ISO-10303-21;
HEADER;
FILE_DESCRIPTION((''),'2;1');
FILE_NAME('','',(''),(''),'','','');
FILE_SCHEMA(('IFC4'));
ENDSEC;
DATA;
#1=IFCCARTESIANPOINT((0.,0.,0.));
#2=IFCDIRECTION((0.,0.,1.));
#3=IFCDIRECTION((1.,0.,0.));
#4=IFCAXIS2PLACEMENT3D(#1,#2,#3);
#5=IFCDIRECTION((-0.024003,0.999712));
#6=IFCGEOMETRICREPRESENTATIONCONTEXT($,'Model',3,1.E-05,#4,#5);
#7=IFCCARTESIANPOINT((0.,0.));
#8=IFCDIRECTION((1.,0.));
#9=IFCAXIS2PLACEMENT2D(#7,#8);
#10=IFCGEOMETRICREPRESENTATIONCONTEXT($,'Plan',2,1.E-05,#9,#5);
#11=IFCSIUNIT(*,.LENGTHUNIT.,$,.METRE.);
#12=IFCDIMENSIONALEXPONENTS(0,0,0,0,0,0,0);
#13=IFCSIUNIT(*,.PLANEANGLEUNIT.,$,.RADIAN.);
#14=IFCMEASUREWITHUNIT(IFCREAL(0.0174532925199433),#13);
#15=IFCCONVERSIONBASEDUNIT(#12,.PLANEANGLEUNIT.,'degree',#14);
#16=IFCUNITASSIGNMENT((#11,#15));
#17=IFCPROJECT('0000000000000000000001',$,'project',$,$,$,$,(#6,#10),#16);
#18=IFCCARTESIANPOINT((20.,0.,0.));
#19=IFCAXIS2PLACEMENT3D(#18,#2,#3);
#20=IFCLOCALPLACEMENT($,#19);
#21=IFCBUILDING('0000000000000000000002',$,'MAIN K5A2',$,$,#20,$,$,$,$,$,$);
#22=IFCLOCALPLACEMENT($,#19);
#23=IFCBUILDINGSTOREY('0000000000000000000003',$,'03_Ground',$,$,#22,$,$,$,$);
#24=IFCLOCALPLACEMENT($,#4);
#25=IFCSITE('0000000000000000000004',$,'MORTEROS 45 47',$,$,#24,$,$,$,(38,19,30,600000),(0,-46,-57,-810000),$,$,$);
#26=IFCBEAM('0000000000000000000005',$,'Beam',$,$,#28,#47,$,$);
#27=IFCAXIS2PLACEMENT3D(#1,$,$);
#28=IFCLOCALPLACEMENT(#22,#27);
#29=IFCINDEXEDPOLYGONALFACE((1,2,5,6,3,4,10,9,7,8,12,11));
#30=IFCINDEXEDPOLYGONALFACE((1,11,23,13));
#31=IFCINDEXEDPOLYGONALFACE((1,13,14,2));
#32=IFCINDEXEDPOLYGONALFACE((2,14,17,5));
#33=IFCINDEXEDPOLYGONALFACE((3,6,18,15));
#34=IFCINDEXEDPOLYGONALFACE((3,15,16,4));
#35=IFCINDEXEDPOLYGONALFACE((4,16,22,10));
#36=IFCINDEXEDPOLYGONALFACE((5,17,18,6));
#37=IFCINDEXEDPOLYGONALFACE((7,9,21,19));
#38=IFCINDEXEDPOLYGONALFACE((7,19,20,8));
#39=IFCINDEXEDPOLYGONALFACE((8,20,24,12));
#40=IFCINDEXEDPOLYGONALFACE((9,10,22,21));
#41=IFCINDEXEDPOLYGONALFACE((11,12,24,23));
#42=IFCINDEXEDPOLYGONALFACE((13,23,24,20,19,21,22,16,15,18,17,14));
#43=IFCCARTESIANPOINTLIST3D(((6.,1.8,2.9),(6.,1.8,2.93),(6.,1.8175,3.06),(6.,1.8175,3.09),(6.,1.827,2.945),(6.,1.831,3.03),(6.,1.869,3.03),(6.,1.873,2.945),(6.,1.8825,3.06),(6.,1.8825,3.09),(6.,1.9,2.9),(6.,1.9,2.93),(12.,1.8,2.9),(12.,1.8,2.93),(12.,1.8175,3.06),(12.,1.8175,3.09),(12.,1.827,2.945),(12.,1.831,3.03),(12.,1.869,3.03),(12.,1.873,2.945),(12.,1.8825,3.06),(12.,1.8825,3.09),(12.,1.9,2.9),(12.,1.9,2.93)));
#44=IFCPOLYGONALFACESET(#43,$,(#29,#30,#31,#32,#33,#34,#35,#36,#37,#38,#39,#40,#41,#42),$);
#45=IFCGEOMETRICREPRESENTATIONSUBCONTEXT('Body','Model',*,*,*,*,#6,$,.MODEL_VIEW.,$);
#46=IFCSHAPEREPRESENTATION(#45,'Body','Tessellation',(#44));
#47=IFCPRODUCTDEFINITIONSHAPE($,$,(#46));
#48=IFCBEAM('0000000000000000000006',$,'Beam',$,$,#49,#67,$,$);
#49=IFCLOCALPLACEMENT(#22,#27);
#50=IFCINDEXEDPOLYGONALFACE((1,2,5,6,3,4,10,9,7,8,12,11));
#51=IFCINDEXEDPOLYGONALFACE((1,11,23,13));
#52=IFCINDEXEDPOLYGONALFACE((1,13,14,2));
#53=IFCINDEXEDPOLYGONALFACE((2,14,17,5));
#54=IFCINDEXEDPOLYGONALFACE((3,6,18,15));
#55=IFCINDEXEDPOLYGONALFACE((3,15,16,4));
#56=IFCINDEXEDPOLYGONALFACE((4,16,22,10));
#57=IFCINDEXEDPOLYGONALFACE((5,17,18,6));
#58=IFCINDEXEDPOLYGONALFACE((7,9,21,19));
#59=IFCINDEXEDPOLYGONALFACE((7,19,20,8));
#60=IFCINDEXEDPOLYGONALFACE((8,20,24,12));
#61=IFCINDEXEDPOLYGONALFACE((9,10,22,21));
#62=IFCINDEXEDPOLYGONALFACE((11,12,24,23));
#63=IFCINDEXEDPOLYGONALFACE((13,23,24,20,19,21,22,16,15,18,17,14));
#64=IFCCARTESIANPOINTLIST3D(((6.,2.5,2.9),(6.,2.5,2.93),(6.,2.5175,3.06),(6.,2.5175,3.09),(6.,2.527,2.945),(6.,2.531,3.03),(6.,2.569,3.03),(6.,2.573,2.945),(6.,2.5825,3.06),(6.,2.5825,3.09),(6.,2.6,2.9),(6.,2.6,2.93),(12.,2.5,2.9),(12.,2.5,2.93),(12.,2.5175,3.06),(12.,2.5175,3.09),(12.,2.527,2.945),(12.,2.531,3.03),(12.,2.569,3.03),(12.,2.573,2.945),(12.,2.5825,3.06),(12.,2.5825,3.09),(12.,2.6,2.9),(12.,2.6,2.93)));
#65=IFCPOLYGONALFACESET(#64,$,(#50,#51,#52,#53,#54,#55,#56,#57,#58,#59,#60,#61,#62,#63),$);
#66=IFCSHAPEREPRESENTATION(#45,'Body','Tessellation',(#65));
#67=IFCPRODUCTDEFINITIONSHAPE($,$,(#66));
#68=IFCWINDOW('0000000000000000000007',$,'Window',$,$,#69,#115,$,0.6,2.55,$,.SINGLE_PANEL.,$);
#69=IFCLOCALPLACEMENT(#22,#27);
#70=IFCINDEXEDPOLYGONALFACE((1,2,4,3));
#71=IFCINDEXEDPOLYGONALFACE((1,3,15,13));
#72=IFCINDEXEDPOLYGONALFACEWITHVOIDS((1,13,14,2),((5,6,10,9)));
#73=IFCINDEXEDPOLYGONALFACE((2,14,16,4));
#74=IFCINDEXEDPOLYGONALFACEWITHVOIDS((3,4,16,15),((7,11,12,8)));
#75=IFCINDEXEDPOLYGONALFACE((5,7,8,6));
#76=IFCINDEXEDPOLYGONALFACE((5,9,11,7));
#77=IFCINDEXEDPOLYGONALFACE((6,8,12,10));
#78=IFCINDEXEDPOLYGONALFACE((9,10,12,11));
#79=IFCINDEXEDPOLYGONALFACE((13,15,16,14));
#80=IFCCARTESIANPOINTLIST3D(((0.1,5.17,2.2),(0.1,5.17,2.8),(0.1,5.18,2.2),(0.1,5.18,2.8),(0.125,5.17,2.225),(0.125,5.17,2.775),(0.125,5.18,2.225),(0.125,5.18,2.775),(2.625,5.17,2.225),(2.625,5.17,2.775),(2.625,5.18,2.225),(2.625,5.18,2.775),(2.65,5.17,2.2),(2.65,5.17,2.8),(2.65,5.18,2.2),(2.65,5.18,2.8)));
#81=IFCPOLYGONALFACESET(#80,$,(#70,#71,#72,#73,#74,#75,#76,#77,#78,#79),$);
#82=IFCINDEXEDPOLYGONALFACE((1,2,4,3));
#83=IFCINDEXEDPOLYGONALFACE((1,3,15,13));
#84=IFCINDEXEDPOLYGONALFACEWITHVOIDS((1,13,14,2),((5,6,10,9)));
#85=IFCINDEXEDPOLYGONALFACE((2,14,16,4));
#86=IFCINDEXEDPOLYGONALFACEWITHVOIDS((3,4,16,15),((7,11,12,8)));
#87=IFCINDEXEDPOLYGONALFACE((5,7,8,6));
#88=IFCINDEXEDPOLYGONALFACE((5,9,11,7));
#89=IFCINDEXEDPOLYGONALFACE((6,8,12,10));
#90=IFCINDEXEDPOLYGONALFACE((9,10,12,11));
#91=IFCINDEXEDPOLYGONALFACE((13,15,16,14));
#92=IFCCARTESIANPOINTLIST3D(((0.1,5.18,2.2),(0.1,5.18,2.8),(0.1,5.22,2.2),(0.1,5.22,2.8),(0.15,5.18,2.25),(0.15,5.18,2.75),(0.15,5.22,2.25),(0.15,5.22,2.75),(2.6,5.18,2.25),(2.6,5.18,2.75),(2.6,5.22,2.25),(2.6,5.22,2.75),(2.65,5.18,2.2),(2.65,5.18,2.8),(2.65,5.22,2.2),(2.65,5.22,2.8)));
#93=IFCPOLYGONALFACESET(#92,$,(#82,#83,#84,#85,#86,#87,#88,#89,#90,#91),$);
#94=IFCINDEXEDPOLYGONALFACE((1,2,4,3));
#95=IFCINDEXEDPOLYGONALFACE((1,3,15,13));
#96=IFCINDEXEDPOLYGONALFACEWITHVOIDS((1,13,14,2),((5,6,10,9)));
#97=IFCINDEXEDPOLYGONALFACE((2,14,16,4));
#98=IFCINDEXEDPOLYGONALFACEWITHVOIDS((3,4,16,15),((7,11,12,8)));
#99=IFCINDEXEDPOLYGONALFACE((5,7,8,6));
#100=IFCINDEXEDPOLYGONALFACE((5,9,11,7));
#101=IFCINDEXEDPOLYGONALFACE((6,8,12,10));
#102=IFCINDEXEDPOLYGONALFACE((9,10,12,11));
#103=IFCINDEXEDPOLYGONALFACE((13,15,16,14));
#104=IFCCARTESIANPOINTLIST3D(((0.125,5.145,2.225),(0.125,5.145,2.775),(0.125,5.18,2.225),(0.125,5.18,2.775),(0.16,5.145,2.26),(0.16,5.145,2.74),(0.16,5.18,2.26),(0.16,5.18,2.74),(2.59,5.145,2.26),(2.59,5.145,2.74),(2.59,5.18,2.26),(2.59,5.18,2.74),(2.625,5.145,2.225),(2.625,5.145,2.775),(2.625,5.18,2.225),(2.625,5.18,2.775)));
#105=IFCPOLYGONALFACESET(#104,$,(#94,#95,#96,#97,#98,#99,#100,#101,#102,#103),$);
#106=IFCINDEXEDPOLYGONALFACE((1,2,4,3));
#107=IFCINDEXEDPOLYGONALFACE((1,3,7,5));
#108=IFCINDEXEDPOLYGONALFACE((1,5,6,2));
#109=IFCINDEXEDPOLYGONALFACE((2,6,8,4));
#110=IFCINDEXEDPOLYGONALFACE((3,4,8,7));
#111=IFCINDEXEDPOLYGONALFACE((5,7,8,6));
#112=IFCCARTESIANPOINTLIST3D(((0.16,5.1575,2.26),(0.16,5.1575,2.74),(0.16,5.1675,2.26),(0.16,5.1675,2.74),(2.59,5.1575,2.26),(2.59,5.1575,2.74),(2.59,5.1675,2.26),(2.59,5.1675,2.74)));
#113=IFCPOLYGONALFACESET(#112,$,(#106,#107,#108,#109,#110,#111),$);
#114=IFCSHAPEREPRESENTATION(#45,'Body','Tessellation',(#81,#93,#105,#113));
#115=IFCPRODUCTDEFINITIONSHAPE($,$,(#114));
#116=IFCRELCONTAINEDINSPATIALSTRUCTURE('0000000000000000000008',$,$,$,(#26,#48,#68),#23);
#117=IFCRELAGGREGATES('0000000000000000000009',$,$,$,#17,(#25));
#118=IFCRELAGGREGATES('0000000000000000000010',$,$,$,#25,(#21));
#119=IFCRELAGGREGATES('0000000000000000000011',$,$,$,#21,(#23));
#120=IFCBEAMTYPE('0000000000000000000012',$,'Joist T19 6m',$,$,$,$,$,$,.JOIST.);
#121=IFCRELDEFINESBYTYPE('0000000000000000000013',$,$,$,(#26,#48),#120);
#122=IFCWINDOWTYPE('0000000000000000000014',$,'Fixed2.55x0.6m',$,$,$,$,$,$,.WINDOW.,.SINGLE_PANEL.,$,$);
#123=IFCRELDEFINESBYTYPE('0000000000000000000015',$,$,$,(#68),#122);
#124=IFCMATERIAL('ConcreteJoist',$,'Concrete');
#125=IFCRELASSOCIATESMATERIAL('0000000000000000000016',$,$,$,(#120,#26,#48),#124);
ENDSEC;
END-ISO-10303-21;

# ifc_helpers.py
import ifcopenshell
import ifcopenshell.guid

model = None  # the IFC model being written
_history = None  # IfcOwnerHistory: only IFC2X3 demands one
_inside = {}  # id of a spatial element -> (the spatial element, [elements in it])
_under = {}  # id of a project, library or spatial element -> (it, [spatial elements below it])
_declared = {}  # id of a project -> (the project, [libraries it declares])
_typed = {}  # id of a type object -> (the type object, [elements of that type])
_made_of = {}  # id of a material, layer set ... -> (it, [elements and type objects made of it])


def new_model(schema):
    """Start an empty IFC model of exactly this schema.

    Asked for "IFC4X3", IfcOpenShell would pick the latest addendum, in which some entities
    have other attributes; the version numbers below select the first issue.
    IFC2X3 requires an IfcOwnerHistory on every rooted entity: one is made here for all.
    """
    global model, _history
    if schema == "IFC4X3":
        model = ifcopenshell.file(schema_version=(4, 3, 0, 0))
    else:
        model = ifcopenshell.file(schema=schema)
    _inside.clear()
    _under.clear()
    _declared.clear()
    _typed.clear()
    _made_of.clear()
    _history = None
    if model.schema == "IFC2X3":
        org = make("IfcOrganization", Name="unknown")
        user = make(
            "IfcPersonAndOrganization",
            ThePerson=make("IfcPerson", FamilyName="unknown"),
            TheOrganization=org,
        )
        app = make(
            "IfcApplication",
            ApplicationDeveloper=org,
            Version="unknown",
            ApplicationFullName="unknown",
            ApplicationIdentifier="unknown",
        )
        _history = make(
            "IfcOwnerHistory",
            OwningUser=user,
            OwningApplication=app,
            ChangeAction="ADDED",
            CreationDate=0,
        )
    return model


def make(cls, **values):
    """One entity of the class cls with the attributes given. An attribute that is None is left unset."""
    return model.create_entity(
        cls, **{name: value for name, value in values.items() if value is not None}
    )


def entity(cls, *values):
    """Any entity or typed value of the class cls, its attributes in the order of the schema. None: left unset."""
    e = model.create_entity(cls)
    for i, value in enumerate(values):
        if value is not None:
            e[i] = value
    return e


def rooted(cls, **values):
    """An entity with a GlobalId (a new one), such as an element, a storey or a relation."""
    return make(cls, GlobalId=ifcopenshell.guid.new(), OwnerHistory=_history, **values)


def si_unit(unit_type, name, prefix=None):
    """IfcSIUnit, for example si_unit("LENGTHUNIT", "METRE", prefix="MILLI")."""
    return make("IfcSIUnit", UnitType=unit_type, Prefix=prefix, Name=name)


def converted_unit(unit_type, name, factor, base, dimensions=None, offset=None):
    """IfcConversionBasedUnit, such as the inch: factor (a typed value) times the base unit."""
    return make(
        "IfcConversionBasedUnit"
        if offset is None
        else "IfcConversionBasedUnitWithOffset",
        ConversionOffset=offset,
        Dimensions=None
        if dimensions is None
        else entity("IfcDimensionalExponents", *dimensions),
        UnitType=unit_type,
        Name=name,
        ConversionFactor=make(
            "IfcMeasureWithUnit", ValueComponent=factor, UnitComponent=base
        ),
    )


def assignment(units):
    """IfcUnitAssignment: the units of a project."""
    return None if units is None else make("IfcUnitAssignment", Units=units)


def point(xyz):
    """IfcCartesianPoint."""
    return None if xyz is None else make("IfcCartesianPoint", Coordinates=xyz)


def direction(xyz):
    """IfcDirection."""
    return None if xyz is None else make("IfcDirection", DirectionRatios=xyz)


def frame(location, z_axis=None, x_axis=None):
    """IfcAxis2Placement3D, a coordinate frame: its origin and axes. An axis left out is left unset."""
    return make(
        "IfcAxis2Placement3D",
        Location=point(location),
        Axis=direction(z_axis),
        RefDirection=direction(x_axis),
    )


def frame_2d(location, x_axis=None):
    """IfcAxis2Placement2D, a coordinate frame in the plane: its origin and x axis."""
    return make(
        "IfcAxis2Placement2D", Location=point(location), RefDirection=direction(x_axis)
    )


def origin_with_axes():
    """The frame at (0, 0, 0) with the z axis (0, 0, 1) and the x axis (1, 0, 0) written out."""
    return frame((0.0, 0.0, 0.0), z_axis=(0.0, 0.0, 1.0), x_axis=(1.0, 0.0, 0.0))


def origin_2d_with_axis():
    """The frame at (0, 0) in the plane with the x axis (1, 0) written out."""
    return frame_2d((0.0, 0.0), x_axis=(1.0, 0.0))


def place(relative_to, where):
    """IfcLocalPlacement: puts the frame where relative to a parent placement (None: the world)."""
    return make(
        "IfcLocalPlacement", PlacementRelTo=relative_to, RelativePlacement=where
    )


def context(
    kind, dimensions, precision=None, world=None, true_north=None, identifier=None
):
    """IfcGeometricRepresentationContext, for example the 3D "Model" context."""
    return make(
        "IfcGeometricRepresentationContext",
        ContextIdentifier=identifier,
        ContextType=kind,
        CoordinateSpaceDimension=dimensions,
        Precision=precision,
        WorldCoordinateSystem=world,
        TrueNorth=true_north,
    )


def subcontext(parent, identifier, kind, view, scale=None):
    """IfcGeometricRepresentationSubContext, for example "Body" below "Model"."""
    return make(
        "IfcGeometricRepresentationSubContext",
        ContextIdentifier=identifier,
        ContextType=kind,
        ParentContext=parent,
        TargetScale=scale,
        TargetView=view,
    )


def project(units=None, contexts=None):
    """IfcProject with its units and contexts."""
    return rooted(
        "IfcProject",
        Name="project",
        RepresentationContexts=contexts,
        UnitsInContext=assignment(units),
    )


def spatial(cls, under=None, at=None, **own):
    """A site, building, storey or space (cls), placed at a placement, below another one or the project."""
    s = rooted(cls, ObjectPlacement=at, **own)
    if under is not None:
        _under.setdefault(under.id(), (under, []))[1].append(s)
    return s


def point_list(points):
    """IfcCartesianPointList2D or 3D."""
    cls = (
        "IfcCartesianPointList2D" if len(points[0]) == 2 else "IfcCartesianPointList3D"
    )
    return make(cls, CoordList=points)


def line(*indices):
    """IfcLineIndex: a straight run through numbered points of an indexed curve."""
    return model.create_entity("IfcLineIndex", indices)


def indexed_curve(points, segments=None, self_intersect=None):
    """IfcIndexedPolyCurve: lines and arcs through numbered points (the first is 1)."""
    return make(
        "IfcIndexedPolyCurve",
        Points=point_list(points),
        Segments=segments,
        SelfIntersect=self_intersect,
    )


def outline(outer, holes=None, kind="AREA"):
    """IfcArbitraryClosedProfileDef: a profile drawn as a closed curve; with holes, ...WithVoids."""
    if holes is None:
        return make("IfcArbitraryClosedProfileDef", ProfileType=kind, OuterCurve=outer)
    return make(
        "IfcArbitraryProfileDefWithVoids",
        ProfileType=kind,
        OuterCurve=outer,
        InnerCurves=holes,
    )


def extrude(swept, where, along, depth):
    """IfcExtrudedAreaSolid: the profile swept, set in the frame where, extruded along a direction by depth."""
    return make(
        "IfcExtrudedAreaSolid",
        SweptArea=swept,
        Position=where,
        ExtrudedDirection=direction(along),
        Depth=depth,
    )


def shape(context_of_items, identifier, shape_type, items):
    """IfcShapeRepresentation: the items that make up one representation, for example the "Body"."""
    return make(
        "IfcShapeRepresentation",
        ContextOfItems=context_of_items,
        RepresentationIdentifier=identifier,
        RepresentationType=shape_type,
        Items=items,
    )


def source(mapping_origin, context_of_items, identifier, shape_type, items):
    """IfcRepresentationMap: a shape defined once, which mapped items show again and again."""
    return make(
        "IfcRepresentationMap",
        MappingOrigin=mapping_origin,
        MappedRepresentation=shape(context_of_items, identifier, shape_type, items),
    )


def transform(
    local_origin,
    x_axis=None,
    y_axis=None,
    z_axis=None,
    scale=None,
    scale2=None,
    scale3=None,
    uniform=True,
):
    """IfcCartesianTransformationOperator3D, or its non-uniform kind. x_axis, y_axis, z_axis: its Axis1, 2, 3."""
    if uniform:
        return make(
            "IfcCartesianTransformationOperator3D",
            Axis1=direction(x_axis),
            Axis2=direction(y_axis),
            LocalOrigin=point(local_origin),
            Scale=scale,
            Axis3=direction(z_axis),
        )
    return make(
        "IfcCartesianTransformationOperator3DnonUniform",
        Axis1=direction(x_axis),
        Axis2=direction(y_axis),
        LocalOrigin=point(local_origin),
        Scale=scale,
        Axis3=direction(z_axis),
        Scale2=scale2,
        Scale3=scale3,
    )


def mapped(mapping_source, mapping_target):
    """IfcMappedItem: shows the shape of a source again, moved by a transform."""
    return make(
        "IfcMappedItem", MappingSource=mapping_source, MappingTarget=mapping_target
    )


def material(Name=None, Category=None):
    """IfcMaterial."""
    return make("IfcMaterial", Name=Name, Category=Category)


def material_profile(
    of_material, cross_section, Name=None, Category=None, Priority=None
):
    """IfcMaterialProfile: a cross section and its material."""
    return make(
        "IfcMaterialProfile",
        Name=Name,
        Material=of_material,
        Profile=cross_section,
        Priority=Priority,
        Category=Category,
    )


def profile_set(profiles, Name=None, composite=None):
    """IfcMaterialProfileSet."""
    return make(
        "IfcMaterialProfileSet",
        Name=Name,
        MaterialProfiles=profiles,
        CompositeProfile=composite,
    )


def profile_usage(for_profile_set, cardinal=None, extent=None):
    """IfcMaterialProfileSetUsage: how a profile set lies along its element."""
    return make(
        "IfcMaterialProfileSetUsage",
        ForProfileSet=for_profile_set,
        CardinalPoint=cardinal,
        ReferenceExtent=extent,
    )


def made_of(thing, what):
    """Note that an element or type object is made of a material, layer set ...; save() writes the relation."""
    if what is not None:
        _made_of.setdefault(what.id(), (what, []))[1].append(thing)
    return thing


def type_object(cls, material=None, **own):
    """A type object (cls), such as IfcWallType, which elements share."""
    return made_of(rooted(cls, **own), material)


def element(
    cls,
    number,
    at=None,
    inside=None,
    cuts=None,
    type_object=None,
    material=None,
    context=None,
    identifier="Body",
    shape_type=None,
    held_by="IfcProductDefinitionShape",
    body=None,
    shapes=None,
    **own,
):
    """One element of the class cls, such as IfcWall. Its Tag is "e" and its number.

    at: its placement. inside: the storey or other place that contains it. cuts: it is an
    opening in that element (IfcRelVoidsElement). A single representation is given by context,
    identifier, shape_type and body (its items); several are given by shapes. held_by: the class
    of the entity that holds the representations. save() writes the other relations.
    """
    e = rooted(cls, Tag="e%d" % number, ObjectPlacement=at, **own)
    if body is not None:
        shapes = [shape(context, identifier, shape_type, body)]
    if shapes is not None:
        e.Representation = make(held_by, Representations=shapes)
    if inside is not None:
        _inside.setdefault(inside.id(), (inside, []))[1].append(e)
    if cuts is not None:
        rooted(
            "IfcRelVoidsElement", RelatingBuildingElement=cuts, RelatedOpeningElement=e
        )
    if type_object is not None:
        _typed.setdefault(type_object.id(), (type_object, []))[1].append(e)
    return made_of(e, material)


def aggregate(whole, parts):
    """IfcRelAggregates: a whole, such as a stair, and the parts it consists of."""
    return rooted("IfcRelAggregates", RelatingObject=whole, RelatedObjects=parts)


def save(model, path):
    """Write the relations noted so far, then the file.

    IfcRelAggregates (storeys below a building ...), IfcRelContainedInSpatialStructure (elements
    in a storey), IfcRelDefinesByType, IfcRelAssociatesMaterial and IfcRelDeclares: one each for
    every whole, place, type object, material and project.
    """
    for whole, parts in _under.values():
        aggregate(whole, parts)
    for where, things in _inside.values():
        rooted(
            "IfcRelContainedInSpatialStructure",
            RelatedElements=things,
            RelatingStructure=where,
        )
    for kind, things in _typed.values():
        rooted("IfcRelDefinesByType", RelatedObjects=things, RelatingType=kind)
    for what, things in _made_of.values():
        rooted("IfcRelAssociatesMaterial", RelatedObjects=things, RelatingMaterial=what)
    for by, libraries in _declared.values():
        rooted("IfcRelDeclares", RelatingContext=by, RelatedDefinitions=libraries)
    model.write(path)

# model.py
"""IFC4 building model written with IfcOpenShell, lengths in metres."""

from ifc_helpers import new_model, entity, si_unit, converted_unit, direction, frame, origin_with_axes, origin_2d_with_axis, place, context, subcontext, project, spatial, line, indexed_curve, outline, extrude, shape, source, transform, mapped, material, material_profile, profile_set, profile_usage, type_object, element, save


model = new_model("IFC4")

# Units and contexts
model_context = context("Model", 3, precision=1e-05, world=origin_with_axes(), true_north=direction((-0.024003, 0.999712)))
plan_context = context("Plan", 2, precision=1e-05, world=origin_2d_with_axis(), true_north=direction((-0.024003, 0.999712)))
body_context_1 = subcontext(model_context, "Body", "Model", "MODEL_VIEW")
body_context_2 = subcontext(plan_context, "Body", "Plan", "PLAN_VIEW")
ifc_project = project(units=[si_unit("LENGTHUNIT", "METRE"), converted_unit("PLANEANGLEUNIT", "degree", entity("IfcReal", 0.0174532925199433), si_unit("PLANEANGLEUNIT", "RADIAN"), dimensions=[0, 0, 0, 0, 0, 0, 0])], contexts=[model_context, plan_context])

# Site, building, storey
site_placement = place(None, origin_with_axes())
site = spatial("IfcSite", under=ifc_project, at=site_placement, Name="MORTEROS 45 47", RefLatitude=(38, 19, 30, 600000), RefLongitude=(0, -46, -57, -810000))
building_placement = place(None, frame((20.0, 0.0, 0.0), z_axis=(0.0, 0.0, 1.0), x_axis=(1.0, 0.0, 0.0)))
building = spatial("IfcBuilding", under=site, at=building_placement, Name="MAIN K5A2")
storey_placement = place(None, frame((20.0, 0.0, 0.0), z_axis=(0.0, 0.0, 1.0), x_axis=(1.0, 0.0, 0.0)))
storey = spatial("IfcBuildingStorey", under=building, at=storey_placement, Name="03_Ground")

# Beams
ifc_material = material(Name="ConcreteJoist", Category="Concrete")
ifc_material_profile = material_profile(ifc_material, outline(indexed_curve([(0.019, 0.13), (0.023, 0.045), (0.05, 0.03), (0.05, 0.0), (-0.05, 0.0), (-0.05, 0.03), (-0.023, 0.045), (-0.019, 0.13), (-0.0325, 0.16), (-0.0325, 0.19), (0.0325, 0.19), (0.0325, 0.16), (0.019, 0.13)])))
ifc_profile_set = profile_set([ifc_material_profile], Name="JoistmaterialProfile")
beam_type = type_object("IfcBeamType", Name="Joist T19 6m", PredefinedType="JOIST", material=ifc_profile_set)
ifc_profile_usage_1 = profile_usage(ifc_profile_set)
beam_1_placement = place(None, frame((26.0, 1.85, 2.9), z_axis=(1.0, 0.0, 0.0), x_axis=(0.0, 1.0, 0.0)))
element("IfcBeam", 1, at=beam_1_placement, inside=storey, type_object=beam_type, material=ifc_profile_usage_1, Name="Beam", context=body_context_1, shape_type="SweptSolid", body=[
    extrude(outline(indexed_curve([(0.019, 0.13), (0.023, 0.045), (0.05, 0.03), (0.05, 0.0), (-0.05, 0.0), (-0.05, 0.03), (-0.023, 0.045), (-0.019, 0.13), (-0.0325, 0.16), (-0.0325, 0.19), (0.0325, 0.19), (0.0325, 0.16), (0.019, 0.13)])), origin_with_axes(), (0.0, 0.0, 1.0), 6.0),
])
ifc_profile_usage_2 = profile_usage(ifc_profile_set)
beam_2_placement = place(None, frame((26.0, 2.55, 2.9), z_axis=(1.0, 0.0, 0.0), x_axis=(0.0, 1.0, 0.0)))
element("IfcBeam", 2, at=beam_2_placement, inside=storey, type_object=beam_type, material=ifc_profile_usage_2, Name="Beam", context=body_context_1, shape_type="SweptSolid", body=[
    extrude(outline(indexed_curve([(0.019, 0.13), (0.023, 0.045), (0.05, 0.03), (0.05, 0.0), (-0.05, 0.0), (-0.05, 0.03), (-0.023, 0.045), (-0.019, 0.13), (-0.0325, 0.16), (-0.0325, 0.19), (0.0325, 0.19), (0.0325, 0.16), (0.019, 0.13)])), origin_with_axes(), (0.0, 0.0, 1.0), 6.0),
])

# Window
window_type_1 = type_object("IfcWindowType", Name="Fixed2.55x0.6m", PartitioningType="SINGLE_PANEL", PredefinedType="WINDOW")
shared_shape_1 = source(origin_with_axes(), body_context_1, "Body", "SolidModel", [
    extrude(outline(indexed_curve([(0.0, 0.0), (2.55, 0.0), (2.55, 0.6), (0.0, 0.6)], segments=[line(1, 2, 3, 4, 1)]), holes=[indexed_curve([(0.025, 0.025), (2.525, 0.025), (2.525, 0.575), (0.025, 0.575)], segments=[line(1, 2, 3, 4, 1)])]), frame((0.0, 0.09, 0.0), z_axis=(0.0, -1.0, 0.0), x_axis=(1.0, 0.0, 0.0)), (0.0, 0.0, -1.0), 0.01),
    extrude(outline(indexed_curve([(0.0, 0.0), (2.55, 0.0), (2.55, 0.6), (0.0, 0.6)], segments=[line(1, 2, 3, 4, 1)]), holes=[indexed_curve([(0.05, 0.05), (2.5, 0.05), (2.5, 0.55), (0.05, 0.55)], segments=[line(1, 2, 3, 4, 1)])]), frame((0.0, 0.05, 0.0), z_axis=(0.0, -1.0, 0.0), x_axis=(1.0, 0.0, 0.0)), (0.0, 0.0, -1.0), 0.04),
    extrude(outline(indexed_curve([(0.0, 0.0), (2.5, 0.0), (2.5, 0.55), (0.0, 0.55)], segments=[line(1, 2, 3, 4, 1)]), holes=[indexed_curve([(0.035, 0.035), (2.465, 0.035), (2.465, 0.515), (0.035, 0.515)], segments=[line(1, 2, 3, 4, 1)])]), frame((0.025, 0.09, 0.025), z_axis=(0.0, -1.0, 0.0), x_axis=(1.0, 0.0, 0.0)), (0.0, 0.0, -1.0), 0.035),
    extrude(outline(indexed_curve([(0.035, 0.035), (2.465, 0.035), (2.465, 0.515), (0.035, 0.515)], segments=[line(1, 2, 3, 4, 1)])), frame((0.025, 0.1025, 0.025), z_axis=(0.0, -1.0, 0.0), x_axis=(1.0, 0.0, 0.0)), (0.0, 0.0, -1.0), 0.01),
])
shared_shape_2 = source(origin_with_axes(), body_context_2, "Body", "Curve2D", [
    entity("IfcIndexedPolyCurve", entity("IfcCartesianPointList2D", [[0.05, 0.05], [2.5, 0.05]])),
    entity("IfcIndexedPolyCurve", entity("IfcCartesianPointList2D", [[0.0, 0.1], [0.025, 0.1], [0.025, 0.09], [0.05, 0.09], [0.05, 0.05], [0.0, 0.05]]), [entity("IfcLineIndex", [1, 2, 3, 4, 5, 6, 1])]),
    entity("IfcIndexedPolyCurve", entity("IfcCartesianPointList2D", [[2.55, 0.1], [2.525, 0.1], [2.525, 0.09], [2.5, 0.09], [2.5, 0.05], [2.55, 0.05]]), [entity("IfcLineIndex", [1, 2, 3, 4, 5, 6, 1])]),
    entity("IfcIndexedPolyCurve", entity("IfcCartesianPointList2D", [[0.025, 0.09], [0.06, 0.09], [0.06, 0.125], [0.025, 0.125]]), [entity("IfcLineIndex", [1, 2, 3, 4, 1])]),
    entity("IfcIndexedPolyCurve", entity("IfcCartesianPointList2D", [[2.525, 0.09], [2.49, 0.09], [2.49, 0.125], [2.525, 0.125]]), [entity("IfcLineIndex", [1, 2, 3, 4, 1])]),
    entity("IfcIndexedPolyCurve", entity("IfcCartesianPointList2D", [[0.06, 0.09], [2.49, 0.09]])),
    entity("IfcIndexedPolyCurve", entity("IfcCartesianPointList2D", [[0.06, 0.125], [2.49, 0.125]])),
    entity("IfcIndexedPolyCurve", entity("IfcCartesianPointList2D", [[0.06, 0.1075], [2.49, 0.1075]])),
])
window_1_placement = place(None, frame((22.65, 5.27, 2.2), z_axis=(0.0, 0.0, 1.0), x_axis=(-1.0, 0.0, 0.0)))
element("IfcWindow", 3, at=window_1_placement, inside=storey, type_object=window_type_1, Name="Window", OverallHeight=0.6, OverallWidth=2.55, PartitioningType="SINGLE_PANEL", shapes=[
    shape(body_context_1, "Body", "MappedRepresentation", [mapped(shared_shape_1, transform((0.0, 0.0, 0.0), x_axis=(1.0, 0.0, 0.0), y_axis=(0.0, 1.0, 0.0), z_axis=(0.0, 0.0, 1.0), scale=1.0))]),
    shape(body_context_2, "Body", "MappedRepresentation", [mapped(shared_shape_2, transform((0.0, 0.0, 0.0), x_axis=(1.0, 0.0, 0.0), y_axis=(0.0, 1.0, 0.0), z_axis=(0.0, 0.0, 1.0), scale=1.0))]),
])

save(model, "model.ifc")
